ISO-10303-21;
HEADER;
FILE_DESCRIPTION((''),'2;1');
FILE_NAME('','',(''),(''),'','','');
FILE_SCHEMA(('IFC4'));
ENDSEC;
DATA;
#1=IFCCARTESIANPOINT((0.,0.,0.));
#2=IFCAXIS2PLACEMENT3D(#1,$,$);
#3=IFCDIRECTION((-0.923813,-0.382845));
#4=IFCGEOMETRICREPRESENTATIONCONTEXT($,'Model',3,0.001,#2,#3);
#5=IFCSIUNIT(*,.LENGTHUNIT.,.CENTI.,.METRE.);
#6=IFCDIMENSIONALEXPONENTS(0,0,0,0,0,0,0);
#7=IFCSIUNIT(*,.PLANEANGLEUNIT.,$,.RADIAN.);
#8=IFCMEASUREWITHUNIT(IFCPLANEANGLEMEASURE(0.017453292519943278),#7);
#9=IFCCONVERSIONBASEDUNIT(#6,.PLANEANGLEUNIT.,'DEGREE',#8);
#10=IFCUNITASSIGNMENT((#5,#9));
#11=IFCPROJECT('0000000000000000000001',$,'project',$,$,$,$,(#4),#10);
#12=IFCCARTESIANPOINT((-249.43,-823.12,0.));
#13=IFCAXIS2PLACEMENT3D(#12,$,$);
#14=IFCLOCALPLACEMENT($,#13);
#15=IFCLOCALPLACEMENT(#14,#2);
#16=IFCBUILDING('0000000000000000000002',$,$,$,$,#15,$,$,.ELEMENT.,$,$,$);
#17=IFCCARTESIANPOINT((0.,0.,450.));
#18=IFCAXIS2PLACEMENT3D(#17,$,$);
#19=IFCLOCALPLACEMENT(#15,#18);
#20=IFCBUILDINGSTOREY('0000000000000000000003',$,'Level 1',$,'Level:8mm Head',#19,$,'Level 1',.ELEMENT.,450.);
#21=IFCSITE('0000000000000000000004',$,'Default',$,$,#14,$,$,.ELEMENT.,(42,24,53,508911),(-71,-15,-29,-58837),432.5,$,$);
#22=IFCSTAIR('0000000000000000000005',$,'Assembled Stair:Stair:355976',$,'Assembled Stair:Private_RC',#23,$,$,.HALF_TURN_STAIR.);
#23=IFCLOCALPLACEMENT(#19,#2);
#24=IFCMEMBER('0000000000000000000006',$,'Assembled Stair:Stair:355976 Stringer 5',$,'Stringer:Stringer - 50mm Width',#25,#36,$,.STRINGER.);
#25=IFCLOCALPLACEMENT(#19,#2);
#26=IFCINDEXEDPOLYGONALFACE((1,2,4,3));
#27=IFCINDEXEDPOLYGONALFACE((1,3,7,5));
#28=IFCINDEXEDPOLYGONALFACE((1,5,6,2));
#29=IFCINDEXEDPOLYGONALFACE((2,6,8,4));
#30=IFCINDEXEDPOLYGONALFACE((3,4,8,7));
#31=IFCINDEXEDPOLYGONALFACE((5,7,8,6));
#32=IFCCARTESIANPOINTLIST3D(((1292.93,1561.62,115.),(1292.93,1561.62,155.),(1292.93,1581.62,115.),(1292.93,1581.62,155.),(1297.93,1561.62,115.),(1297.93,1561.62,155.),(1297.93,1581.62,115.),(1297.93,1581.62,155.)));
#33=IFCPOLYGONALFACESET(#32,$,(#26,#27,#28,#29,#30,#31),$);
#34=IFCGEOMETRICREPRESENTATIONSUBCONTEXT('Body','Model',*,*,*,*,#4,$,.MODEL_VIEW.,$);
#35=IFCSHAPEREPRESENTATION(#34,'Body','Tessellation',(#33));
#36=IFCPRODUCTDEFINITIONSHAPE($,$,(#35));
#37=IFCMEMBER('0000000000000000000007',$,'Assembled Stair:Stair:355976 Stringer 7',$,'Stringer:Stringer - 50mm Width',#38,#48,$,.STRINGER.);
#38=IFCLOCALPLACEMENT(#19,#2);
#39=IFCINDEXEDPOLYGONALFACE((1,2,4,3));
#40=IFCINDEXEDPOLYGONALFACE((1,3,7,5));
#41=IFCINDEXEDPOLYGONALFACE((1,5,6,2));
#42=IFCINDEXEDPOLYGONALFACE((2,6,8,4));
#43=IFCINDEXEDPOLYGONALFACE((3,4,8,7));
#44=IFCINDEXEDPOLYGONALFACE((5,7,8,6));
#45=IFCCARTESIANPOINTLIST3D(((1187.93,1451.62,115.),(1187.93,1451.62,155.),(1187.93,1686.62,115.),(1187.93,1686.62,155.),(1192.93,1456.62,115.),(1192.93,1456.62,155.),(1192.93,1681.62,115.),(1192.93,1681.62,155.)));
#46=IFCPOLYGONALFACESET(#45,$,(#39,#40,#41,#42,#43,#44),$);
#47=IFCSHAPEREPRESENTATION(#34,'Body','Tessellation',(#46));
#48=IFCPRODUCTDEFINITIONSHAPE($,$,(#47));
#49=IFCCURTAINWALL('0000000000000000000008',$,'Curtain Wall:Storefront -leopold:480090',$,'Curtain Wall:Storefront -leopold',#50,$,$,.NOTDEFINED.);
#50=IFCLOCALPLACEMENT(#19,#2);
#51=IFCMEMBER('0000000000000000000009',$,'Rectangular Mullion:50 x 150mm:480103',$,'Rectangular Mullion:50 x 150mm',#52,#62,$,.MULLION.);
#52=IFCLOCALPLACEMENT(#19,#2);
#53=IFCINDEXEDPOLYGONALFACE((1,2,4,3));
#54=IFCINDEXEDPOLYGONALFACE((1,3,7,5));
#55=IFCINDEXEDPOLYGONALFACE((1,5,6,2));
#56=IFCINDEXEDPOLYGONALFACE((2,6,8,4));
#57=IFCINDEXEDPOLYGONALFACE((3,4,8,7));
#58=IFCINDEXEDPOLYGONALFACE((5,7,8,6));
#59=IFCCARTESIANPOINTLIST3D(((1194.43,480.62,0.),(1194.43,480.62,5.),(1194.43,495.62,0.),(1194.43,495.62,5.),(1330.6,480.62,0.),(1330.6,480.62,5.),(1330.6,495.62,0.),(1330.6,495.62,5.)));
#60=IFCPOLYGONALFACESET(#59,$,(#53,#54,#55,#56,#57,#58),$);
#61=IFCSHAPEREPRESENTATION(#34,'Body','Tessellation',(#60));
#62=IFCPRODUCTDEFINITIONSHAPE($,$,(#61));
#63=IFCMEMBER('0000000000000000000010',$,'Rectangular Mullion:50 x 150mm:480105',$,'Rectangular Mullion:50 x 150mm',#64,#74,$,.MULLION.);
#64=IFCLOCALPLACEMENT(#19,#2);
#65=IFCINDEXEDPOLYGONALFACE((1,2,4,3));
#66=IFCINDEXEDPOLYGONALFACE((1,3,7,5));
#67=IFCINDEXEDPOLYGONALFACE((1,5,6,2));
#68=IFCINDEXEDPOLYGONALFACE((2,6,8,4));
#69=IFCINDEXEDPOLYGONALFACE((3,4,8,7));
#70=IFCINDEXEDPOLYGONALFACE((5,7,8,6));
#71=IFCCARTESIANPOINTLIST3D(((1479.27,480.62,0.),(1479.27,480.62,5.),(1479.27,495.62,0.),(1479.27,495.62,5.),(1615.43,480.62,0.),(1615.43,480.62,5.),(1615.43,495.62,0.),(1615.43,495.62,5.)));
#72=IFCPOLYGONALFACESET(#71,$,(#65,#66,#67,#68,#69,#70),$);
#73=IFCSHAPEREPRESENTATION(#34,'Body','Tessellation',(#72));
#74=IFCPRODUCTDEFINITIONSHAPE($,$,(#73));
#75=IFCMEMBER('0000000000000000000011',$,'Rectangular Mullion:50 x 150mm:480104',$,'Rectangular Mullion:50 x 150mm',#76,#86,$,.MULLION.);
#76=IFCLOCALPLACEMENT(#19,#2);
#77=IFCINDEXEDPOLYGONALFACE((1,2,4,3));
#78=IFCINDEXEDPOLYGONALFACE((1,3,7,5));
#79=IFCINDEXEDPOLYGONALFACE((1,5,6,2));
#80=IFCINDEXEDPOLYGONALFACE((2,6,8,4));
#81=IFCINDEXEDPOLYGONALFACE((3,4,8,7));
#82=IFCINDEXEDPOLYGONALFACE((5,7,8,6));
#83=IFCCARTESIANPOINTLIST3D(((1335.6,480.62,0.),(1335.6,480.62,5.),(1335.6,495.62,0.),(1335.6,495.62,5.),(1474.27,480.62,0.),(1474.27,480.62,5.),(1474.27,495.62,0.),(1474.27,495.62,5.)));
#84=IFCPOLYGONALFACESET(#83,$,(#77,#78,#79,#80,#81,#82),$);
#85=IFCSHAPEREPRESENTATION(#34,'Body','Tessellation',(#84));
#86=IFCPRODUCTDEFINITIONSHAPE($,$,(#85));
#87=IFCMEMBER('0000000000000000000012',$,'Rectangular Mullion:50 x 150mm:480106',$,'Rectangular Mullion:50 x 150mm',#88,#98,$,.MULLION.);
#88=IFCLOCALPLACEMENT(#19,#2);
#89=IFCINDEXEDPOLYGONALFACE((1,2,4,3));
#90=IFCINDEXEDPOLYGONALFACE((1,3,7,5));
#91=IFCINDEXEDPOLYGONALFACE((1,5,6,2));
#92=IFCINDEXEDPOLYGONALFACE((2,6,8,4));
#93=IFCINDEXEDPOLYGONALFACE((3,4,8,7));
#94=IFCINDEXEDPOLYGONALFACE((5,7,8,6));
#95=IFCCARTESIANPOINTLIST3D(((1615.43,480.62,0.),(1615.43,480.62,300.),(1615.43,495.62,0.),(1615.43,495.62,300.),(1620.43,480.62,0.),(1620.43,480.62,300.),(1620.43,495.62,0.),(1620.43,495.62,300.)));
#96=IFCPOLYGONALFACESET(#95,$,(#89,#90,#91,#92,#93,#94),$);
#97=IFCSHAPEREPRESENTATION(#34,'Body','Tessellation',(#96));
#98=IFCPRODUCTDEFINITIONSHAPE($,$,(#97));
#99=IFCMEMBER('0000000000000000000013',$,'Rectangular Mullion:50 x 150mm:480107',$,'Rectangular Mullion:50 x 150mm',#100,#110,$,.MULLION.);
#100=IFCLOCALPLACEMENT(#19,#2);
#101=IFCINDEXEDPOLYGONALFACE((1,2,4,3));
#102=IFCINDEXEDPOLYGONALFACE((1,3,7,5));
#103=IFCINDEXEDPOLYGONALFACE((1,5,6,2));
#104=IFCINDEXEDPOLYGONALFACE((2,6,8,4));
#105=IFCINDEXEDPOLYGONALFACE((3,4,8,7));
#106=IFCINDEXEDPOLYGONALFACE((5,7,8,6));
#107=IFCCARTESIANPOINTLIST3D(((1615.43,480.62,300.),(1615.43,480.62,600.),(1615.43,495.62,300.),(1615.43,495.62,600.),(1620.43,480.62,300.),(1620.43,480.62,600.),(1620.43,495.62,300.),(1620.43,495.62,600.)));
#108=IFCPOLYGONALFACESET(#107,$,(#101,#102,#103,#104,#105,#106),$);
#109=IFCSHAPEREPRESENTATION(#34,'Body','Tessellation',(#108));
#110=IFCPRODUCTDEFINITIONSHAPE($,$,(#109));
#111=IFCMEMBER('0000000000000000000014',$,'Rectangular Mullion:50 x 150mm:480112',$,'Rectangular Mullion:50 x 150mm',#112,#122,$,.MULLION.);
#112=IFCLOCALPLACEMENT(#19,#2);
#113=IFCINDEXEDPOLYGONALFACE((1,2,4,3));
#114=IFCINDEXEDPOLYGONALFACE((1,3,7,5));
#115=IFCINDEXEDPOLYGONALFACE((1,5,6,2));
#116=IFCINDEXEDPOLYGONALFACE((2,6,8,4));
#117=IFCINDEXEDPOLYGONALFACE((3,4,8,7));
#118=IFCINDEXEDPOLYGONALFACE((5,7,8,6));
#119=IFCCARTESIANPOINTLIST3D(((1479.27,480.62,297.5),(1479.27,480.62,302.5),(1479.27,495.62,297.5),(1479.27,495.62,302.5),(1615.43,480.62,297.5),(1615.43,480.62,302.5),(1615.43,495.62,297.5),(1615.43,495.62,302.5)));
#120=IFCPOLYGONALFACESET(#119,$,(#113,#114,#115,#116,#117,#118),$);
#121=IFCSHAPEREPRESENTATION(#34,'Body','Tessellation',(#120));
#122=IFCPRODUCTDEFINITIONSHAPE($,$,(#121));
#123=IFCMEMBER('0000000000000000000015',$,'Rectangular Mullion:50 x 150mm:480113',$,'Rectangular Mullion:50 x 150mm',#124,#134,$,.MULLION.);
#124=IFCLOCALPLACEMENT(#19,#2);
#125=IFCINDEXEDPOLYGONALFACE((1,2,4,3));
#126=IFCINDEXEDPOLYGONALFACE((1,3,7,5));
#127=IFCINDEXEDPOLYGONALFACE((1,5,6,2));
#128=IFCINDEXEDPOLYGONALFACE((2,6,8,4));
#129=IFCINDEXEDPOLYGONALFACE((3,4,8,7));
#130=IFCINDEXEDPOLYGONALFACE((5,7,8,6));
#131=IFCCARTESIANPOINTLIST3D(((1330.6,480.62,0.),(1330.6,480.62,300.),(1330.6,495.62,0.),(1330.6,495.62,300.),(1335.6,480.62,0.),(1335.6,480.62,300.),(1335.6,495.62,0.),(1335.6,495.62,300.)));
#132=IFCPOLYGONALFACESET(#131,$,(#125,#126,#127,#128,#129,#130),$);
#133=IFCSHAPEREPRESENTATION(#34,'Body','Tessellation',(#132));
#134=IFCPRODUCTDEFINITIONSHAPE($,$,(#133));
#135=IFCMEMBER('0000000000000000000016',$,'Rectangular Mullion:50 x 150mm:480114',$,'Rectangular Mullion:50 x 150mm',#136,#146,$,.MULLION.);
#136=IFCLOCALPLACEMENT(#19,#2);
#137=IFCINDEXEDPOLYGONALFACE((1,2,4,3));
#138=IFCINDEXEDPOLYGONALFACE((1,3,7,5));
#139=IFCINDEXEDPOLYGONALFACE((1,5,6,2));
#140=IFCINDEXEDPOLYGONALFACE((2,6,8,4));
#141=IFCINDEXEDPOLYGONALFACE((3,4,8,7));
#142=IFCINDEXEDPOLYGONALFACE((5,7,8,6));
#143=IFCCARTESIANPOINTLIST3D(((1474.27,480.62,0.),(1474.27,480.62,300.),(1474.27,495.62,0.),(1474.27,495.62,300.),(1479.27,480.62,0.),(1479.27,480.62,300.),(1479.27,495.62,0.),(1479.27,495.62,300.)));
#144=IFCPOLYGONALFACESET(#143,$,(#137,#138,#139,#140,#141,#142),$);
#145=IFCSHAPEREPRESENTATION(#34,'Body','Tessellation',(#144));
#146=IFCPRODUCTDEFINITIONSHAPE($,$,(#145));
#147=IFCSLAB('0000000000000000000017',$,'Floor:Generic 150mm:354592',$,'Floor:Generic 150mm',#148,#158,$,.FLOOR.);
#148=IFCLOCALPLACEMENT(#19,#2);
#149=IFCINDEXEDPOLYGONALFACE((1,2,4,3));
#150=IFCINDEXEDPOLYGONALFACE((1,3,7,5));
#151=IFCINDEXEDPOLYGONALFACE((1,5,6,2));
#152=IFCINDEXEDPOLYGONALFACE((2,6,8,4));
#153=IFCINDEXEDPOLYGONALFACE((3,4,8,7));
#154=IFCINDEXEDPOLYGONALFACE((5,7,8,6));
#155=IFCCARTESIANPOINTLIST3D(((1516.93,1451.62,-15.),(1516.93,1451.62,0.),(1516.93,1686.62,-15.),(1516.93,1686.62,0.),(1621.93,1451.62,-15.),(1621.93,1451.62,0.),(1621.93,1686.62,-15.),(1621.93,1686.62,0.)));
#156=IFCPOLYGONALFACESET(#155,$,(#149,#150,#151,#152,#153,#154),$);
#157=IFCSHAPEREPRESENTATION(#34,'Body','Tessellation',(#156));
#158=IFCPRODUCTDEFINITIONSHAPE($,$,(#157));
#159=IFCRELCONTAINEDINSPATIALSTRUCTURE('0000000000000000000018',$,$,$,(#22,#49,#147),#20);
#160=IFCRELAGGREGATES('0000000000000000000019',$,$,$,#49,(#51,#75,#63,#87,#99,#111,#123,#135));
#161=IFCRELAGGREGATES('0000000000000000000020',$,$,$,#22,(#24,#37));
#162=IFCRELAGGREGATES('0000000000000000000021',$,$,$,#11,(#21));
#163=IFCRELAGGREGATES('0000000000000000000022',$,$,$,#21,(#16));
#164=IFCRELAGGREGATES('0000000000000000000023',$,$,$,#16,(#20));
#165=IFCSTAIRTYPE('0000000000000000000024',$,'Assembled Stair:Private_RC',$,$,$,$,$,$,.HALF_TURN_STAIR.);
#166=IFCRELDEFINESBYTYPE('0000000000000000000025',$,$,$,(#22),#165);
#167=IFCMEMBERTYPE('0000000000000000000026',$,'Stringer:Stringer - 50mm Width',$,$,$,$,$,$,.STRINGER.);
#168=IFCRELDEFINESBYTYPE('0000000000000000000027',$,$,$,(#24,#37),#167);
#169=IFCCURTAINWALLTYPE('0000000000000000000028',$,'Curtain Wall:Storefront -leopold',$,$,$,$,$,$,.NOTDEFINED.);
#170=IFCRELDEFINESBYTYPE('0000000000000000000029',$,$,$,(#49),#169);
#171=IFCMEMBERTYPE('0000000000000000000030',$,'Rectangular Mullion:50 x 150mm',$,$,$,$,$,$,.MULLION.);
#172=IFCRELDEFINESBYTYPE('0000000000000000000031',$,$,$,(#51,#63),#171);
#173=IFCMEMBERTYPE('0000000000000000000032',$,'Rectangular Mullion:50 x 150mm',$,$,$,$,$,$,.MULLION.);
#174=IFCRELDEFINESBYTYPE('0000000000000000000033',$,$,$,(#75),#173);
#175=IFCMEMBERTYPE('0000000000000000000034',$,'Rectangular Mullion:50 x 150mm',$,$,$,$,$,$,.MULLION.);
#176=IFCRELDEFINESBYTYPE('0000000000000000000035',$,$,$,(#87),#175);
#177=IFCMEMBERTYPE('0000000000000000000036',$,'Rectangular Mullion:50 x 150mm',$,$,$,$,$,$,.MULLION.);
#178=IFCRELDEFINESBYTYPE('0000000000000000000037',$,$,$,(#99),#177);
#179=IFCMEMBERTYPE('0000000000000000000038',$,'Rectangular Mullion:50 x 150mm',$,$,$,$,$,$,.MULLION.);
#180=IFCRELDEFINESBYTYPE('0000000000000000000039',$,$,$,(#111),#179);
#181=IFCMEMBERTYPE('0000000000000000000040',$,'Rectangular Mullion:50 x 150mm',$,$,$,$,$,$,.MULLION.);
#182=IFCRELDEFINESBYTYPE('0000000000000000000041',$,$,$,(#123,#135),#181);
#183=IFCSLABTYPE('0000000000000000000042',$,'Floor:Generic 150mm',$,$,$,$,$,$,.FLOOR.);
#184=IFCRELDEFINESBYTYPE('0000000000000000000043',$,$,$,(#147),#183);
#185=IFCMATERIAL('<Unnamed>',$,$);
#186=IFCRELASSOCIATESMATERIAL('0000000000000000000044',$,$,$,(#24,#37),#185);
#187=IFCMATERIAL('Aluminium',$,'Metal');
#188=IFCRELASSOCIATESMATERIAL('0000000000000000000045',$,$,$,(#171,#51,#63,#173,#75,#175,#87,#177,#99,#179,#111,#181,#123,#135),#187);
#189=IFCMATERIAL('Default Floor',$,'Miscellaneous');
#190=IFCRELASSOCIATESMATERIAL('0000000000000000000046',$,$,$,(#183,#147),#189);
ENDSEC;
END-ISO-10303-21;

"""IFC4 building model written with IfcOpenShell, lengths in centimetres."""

from ifc_helpers import new_model, entity, si_unit, converted_unit, direction, frame, origin, place, context, subcontext, project, spatial, indexed_curve, outline, extrude, source, transform, mapped, material, type_object, type_shapes, element, aggregate, save


model = new_model("IFC4")

# Units and contexts
model_context = context("Model", 3, precision=0.001, world=origin(), true_north=direction((-0.923813, -0.382845)))
body_context = subcontext(model_context, "Body", "Model", "MODEL_VIEW")
ifc_project = project(units=[si_unit("LENGTHUNIT", "METRE", prefix="CENTI"), converted_unit("PLANEANGLEUNIT", "DEGREE", entity("IfcPlaneAngleMeasure", 0.017453292519943278), si_unit("PLANEANGLEUNIT", "RADIAN"), dimensions=[0, 0, 0, 0, 0, 0, 0])], contexts=[model_context])

# Site, building, storey
site_placement = place(None, frame((-249.43, -823.12, 0.0)))
site = spatial("IfcSite", under=ifc_project, at=site_placement, Name="Default", CompositionType="ELEMENT", RefLatitude=(42, 24, 53, 508911), RefLongitude=(-71, -15, -29, -58837), RefElevation=432.5)
building_placement = place(site_placement, origin())
building = spatial("IfcBuilding", under=site, at=building_placement, CompositionType="ELEMENT")
storey_placement = place(building_placement, frame((0.0, 0.0, 450.0)))
storey = spatial("IfcBuildingStorey", under=building, at=storey_placement, Name="Level 1", ObjectType="Level:8mm Head", LongName="Level 1", CompositionType="ELEMENT", Elevation=450.0)

# Stair, members
stair_type = type_object("IfcStairType", Name="Assembled Stair:Private_RC", PredefinedType="HALF_TURN_STAIR")
stair_placement = place(storey_placement, origin())
stair = element("IfcStair", 1, at=stair_placement, inside=storey, type_object=stair_type, Name="Assembled Stair:Stair:355976", ObjectType="Assembled Stair:Private_RC", PredefinedType="HALF_TURN_STAIR")
ifc_material_1 = material(Name="<Unnamed>")
member_type_1 = type_object("IfcMemberType", Name="Stringer:Stringer - 50mm Width", PredefinedType="STRINGER")
member_1_placement = place(stair_placement, origin())
member_1 = element("IfcMember", 2, at=member_1_placement, type_object=member_type_1, material=ifc_material_1, Name="Assembled Stair:Stair:355976 Stringer 5", ObjectType="Stringer:Stringer - 50mm Width", PredefinedType="STRINGER", context=body_context, shape_type="SweptSolid", body=[
    extrude(outline(indexed_curve([(-10.0, -2.5), (10.0, -2.5), (10.0, 2.5), (-10.0, 2.5), (-10.0, -2.5)], self_intersect=False)), frame((1295.43, 1571.62, 115.0), z_axis=(0.0, 0.0, 1.0), x_axis=(0.0, 1.0, 0.0)), (0.0, 0.0, 1.0), 40.0),
])
member_2_placement = place(stair_placement, origin())
member_2 = element("IfcMember", 3, at=member_2_placement, type_object=member_type_1, material=ifc_material_1, Name="Assembled Stair:Stair:355976 Stringer 7", ObjectType="Stringer:Stringer - 50mm Width", PredefinedType="STRINGER", context=body_context, shape_type="SweptSolid", body=[
    extrude(outline(indexed_curve([(-117.5, -2.5), (117.5, -2.5), (112.5, 2.5), (-112.5, 2.5), (-117.5, -2.5)], self_intersect=False)), frame((1190.43, 1569.12, 115.0), z_axis=(0.0, 0.0, 1.0), x_axis=(0.0, -1.0, 0.0)), (0.0, 0.0, 1.0), 40.0),
])

# Curtain wall, members
curtain_wall_type = type_object("IfcCurtainWallType", Name="Curtain Wall:Storefront -leopold", PredefinedType="NOTDEFINED")
curtain_wall_placement = place(storey_placement, frame((0.0, 0.0, -450.0)))
curtain_wall = element("IfcCurtainWall", 4, at=curtain_wall_placement, inside=storey, type_object=curtain_wall_type, Name="Curtain Wall:Storefront -leopold:480090", ObjectType="Curtain Wall:Storefront -leopold", PredefinedType="NOTDEFINED")
ifc_material_2 = material(Name="Aluminium", Category="Metal")
member_type_2 = type_object("IfcMemberType", Name="Rectangular Mullion:50 x 150mm", PredefinedType="MULLION", material=ifc_material_2)
shared_shape_1 = source(origin(), body_context, "Body", "SweptSolid", [
    extrude(outline(indexed_curve([(-2.5, -7.5), (2.5, -7.5), (2.5, 7.5), (-2.5, 7.5), (-2.5, -7.5)], self_intersect=False)), frame((-2.5, 0.0, -136.17), z_axis=(0.0, 0.0, 1.0), x_axis=(-1.0, 0.0, 0.0)), (0.0, 0.0, 1.0), 136.17),
])
type_shapes(member_type_2, [shared_shape_1])
member_3_placement = place(curtain_wall_placement, frame((1194.43, 488.12, 450.0), z_axis=(-1.0, 0.0, 0.0), x_axis=(0.0, 0.0, -1.0)))
member_3 = element("IfcMember", 5, at=member_3_placement, type_object=member_type_2, material=ifc_material_2, Name="Rectangular Mullion:50 x 150mm:480103", ObjectType="Rectangular Mullion:50 x 150mm", PredefinedType="MULLION", context=body_context, shape_type="MappedRepresentation", body=[
    mapped(shared_shape_1, transform((0.0, 0.0, 0.0), scale=1.0)),
])
member_4_placement = place(curtain_wall_placement, frame((1479.27, 488.12, 450.0), z_axis=(-1.0, 0.0, 0.0), x_axis=(0.0, 0.0, -1.0)))
member_4 = element("IfcMember", 6, at=member_4_placement, type_object=member_type_2, material=ifc_material_2, Name="Rectangular Mullion:50 x 150mm:480105", ObjectType="Rectangular Mullion:50 x 150mm", PredefinedType="MULLION", context=body_context, shape_type="MappedRepresentation", body=[
    mapped(shared_shape_1, transform((0.0, 0.0, 0.0), scale=1.0)),
])
member_type_3 = type_object("IfcMemberType", Name="Rectangular Mullion:50 x 150mm", PredefinedType="MULLION", material=ifc_material_2)
shared_shape_2 = source(origin(), body_context, "Body", "SweptSolid", [
    extrude(outline(indexed_curve([(-2.5, -7.5), (2.5, -7.5), (2.5, 7.5), (-2.5, 7.5), (-2.5, -7.5)], self_intersect=False)), frame((-2.5, 0.0, -138.67), z_axis=(0.0, 0.0, 1.0), x_axis=(-1.0, 0.0, 0.0)), (0.0, 0.0, 1.0), 138.67),
])
type_shapes(member_type_3, [shared_shape_2])
member_5_placement = place(curtain_wall_placement, frame((1335.6, 488.12, 450.0), z_axis=(-1.0, 0.0, 0.0), x_axis=(0.0, 0.0, -1.0)))
member_5 = element("IfcMember", 7, at=member_5_placement, type_object=member_type_3, material=ifc_material_2, Name="Rectangular Mullion:50 x 150mm:480104", ObjectType="Rectangular Mullion:50 x 150mm", PredefinedType="MULLION", context=body_context, shape_type="MappedRepresentation", body=[
    mapped(shared_shape_2, transform((0.0, 0.0, 0.0), scale=1.0)),
])
member_type_4 = type_object("IfcMemberType", Name="Rectangular Mullion:50 x 150mm", PredefinedType="MULLION", material=ifc_material_2)
shared_shape_3 = source(origin(), body_context, "Body", "SweptSolid", [
    extrude(outline(indexed_curve([(-2.5, -7.5), (2.5, -7.5), (2.5, 7.5), (-2.5, 7.5), (-2.5, -7.5)], self_intersect=False)), frame((-2.5, 0.0, -300.0), z_axis=(0.0, 0.0, 1.0), x_axis=(-1.0, 0.0, 0.0)), (0.0, 0.0, 1.0), 300.0),
])
type_shapes(member_type_4, [shared_shape_3])
member_6_placement = place(curtain_wall_placement, frame((1620.43, 488.12, 450.0), z_axis=(0.0, 0.0, -1.0), x_axis=(1.0, 0.0, 0.0)))
member_6 = element("IfcMember", 8, at=member_6_placement, type_object=member_type_4, material=ifc_material_2, Name="Rectangular Mullion:50 x 150mm:480106", ObjectType="Rectangular Mullion:50 x 150mm", PredefinedType="MULLION", context=body_context, shape_type="MappedRepresentation", body=[
    mapped(shared_shape_3, transform((0.0, 0.0, 0.0), scale=1.0)),
])
member_type_5 = type_object("IfcMemberType", Name="Rectangular Mullion:50 x 150mm", PredefinedType="MULLION", material=ifc_material_2)
shared_shape_4 = source(origin(), body_context, "Body", "SweptSolid", [
    extrude(outline(indexed_curve([(-2.5, -7.5), (2.5, -7.5), (2.5, 7.5), (-2.5, 7.5), (-2.5, -7.5)], self_intersect=False)), frame((-2.5, 0.0, -300.0), z_axis=(0.0, 0.0, 1.0), x_axis=(-1.0, 0.0, 0.0)), (0.0, 0.0, 1.0), 300.0),
])
type_shapes(member_type_5, [shared_shape_4])
member_7_placement = place(curtain_wall_placement, frame((1620.43, 488.12, 750.0), z_axis=(0.0, 0.0, -1.0), x_axis=(1.0, 0.0, 0.0)))
member_7 = element("IfcMember", 9, at=member_7_placement, type_object=member_type_5, material=ifc_material_2, Name="Rectangular Mullion:50 x 150mm:480107", ObjectType="Rectangular Mullion:50 x 150mm", PredefinedType="MULLION", context=body_context, shape_type="MappedRepresentation", body=[
    mapped(shared_shape_4, transform((0.0, 0.0, 0.0), scale=1.0)),
])
member_type_6 = type_object("IfcMemberType", Name="Rectangular Mullion:50 x 150mm", PredefinedType="MULLION", material=ifc_material_2)
shared_shape_5 = source(origin(), body_context, "Body", "SweptSolid", [
    extrude(outline(indexed_curve([(-2.5, -7.5), (2.5, -7.5), (2.5, 7.5), (-2.5, 7.5), (-2.5, -7.5)], self_intersect=False)), frame((0.0, 0.0, -136.17), z_axis=(0.0, 0.0, 1.0), x_axis=(-1.0, 0.0, 0.0)), (0.0, 0.0, 1.0), 136.17),
])
type_shapes(member_type_6, [shared_shape_5])
member_8_placement = place(curtain_wall_placement, frame((1615.43, 488.12, 750.0), z_axis=(1.0, 0.0, 0.0), x_axis=(0.0, 0.0, 1.0)))
member_8 = element("IfcMember", 10, at=member_8_placement, type_object=member_type_6, material=ifc_material_2, Name="Rectangular Mullion:50 x 150mm:480112", ObjectType="Rectangular Mullion:50 x 150mm", PredefinedType="MULLION", context=body_context, shape_type="MappedRepresentation", body=[
    mapped(shared_shape_5, transform((0.0, 0.0, 0.0), scale=1.0)),
])
member_type_7 = type_object("IfcMemberType", Name="Rectangular Mullion:50 x 150mm", PredefinedType="MULLION", material=ifc_material_2)
shared_shape_6 = source(origin(), body_context, "Body", "SweptSolid", [
    extrude(outline(indexed_curve([(-2.5, -7.5), (2.5, -7.5), (2.5, 7.5), (-2.5, 7.5), (-2.5, -7.5)], self_intersect=False)), frame((0.0, 0.0, -300.0), z_axis=(0.0, 0.0, 1.0), x_axis=(-1.0, 0.0, 0.0)), (0.0, 0.0, 1.0), 300.0),
])
type_shapes(member_type_7, [shared_shape_6])
member_9_placement = place(curtain_wall_placement, frame((1333.1, 488.12, 450.0), z_axis=(0.0, 0.0, -1.0), x_axis=(1.0, 0.0, 0.0)))
member_9 = element("IfcMember", 11, at=member_9_placement, type_object=member_type_7, material=ifc_material_2, Name="Rectangular Mullion:50 x 150mm:480113", ObjectType="Rectangular Mullion:50 x 150mm", PredefinedType="MULLION", context=body_context, shape_type="MappedRepresentation", body=[
    mapped(shared_shape_6, transform((0.0, 0.0, 0.0), scale=1.0)),
])
member_10_placement = place(curtain_wall_placement, frame((1476.77, 488.12, 450.0), z_axis=(0.0, 0.0, -1.0), x_axis=(1.0, 0.0, 0.0)))
member_10 = element("IfcMember", 12, at=member_10_placement, type_object=member_type_7, material=ifc_material_2, Name="Rectangular Mullion:50 x 150mm:480114", ObjectType="Rectangular Mullion:50 x 150mm", PredefinedType="MULLION", context=body_context, shape_type="MappedRepresentation", body=[
    mapped(shared_shape_6, transform((0.0, 0.0, 0.0), scale=1.0)),
])

# Slab
ifc_material_3 = material(Name="Default Floor", Category="Miscellaneous")
slab_type_1 = type_object("IfcSlabType", Name="Floor:Generic 150mm", PredefinedType="FLOOR", material=ifc_material_3)
slab_1_placement = place(storey_placement, origin())
element("IfcSlab", 13, at=slab_1_placement, inside=storey, type_object=slab_type_1, material=ifc_material_3, Name="Floor:Generic 150mm:354592", ObjectType="Floor:Generic 150mm", PredefinedType="FLOOR", context=body_context, shape_type="SweptSolid", body=[
    extrude(outline(indexed_curve([(-117.5, -52.5), (117.5, -52.5), (117.5, 52.5), (-117.5, 52.5), (-117.5, -52.5)], self_intersect=False)), frame((1569.43, 1569.12, 0.0), z_axis=(0.0, 0.0, -1.0), x_axis=(0.0, 1.0, 0.0)), (0.0, 0.0, 1.0), 15.0),
])

aggregate(curtain_wall, [member_3, member_5, member_4, member_6, member_7, member_8, member_9, member_10])

aggregate(stair, [member_1, member_2])

save(model, "model.ifc")
